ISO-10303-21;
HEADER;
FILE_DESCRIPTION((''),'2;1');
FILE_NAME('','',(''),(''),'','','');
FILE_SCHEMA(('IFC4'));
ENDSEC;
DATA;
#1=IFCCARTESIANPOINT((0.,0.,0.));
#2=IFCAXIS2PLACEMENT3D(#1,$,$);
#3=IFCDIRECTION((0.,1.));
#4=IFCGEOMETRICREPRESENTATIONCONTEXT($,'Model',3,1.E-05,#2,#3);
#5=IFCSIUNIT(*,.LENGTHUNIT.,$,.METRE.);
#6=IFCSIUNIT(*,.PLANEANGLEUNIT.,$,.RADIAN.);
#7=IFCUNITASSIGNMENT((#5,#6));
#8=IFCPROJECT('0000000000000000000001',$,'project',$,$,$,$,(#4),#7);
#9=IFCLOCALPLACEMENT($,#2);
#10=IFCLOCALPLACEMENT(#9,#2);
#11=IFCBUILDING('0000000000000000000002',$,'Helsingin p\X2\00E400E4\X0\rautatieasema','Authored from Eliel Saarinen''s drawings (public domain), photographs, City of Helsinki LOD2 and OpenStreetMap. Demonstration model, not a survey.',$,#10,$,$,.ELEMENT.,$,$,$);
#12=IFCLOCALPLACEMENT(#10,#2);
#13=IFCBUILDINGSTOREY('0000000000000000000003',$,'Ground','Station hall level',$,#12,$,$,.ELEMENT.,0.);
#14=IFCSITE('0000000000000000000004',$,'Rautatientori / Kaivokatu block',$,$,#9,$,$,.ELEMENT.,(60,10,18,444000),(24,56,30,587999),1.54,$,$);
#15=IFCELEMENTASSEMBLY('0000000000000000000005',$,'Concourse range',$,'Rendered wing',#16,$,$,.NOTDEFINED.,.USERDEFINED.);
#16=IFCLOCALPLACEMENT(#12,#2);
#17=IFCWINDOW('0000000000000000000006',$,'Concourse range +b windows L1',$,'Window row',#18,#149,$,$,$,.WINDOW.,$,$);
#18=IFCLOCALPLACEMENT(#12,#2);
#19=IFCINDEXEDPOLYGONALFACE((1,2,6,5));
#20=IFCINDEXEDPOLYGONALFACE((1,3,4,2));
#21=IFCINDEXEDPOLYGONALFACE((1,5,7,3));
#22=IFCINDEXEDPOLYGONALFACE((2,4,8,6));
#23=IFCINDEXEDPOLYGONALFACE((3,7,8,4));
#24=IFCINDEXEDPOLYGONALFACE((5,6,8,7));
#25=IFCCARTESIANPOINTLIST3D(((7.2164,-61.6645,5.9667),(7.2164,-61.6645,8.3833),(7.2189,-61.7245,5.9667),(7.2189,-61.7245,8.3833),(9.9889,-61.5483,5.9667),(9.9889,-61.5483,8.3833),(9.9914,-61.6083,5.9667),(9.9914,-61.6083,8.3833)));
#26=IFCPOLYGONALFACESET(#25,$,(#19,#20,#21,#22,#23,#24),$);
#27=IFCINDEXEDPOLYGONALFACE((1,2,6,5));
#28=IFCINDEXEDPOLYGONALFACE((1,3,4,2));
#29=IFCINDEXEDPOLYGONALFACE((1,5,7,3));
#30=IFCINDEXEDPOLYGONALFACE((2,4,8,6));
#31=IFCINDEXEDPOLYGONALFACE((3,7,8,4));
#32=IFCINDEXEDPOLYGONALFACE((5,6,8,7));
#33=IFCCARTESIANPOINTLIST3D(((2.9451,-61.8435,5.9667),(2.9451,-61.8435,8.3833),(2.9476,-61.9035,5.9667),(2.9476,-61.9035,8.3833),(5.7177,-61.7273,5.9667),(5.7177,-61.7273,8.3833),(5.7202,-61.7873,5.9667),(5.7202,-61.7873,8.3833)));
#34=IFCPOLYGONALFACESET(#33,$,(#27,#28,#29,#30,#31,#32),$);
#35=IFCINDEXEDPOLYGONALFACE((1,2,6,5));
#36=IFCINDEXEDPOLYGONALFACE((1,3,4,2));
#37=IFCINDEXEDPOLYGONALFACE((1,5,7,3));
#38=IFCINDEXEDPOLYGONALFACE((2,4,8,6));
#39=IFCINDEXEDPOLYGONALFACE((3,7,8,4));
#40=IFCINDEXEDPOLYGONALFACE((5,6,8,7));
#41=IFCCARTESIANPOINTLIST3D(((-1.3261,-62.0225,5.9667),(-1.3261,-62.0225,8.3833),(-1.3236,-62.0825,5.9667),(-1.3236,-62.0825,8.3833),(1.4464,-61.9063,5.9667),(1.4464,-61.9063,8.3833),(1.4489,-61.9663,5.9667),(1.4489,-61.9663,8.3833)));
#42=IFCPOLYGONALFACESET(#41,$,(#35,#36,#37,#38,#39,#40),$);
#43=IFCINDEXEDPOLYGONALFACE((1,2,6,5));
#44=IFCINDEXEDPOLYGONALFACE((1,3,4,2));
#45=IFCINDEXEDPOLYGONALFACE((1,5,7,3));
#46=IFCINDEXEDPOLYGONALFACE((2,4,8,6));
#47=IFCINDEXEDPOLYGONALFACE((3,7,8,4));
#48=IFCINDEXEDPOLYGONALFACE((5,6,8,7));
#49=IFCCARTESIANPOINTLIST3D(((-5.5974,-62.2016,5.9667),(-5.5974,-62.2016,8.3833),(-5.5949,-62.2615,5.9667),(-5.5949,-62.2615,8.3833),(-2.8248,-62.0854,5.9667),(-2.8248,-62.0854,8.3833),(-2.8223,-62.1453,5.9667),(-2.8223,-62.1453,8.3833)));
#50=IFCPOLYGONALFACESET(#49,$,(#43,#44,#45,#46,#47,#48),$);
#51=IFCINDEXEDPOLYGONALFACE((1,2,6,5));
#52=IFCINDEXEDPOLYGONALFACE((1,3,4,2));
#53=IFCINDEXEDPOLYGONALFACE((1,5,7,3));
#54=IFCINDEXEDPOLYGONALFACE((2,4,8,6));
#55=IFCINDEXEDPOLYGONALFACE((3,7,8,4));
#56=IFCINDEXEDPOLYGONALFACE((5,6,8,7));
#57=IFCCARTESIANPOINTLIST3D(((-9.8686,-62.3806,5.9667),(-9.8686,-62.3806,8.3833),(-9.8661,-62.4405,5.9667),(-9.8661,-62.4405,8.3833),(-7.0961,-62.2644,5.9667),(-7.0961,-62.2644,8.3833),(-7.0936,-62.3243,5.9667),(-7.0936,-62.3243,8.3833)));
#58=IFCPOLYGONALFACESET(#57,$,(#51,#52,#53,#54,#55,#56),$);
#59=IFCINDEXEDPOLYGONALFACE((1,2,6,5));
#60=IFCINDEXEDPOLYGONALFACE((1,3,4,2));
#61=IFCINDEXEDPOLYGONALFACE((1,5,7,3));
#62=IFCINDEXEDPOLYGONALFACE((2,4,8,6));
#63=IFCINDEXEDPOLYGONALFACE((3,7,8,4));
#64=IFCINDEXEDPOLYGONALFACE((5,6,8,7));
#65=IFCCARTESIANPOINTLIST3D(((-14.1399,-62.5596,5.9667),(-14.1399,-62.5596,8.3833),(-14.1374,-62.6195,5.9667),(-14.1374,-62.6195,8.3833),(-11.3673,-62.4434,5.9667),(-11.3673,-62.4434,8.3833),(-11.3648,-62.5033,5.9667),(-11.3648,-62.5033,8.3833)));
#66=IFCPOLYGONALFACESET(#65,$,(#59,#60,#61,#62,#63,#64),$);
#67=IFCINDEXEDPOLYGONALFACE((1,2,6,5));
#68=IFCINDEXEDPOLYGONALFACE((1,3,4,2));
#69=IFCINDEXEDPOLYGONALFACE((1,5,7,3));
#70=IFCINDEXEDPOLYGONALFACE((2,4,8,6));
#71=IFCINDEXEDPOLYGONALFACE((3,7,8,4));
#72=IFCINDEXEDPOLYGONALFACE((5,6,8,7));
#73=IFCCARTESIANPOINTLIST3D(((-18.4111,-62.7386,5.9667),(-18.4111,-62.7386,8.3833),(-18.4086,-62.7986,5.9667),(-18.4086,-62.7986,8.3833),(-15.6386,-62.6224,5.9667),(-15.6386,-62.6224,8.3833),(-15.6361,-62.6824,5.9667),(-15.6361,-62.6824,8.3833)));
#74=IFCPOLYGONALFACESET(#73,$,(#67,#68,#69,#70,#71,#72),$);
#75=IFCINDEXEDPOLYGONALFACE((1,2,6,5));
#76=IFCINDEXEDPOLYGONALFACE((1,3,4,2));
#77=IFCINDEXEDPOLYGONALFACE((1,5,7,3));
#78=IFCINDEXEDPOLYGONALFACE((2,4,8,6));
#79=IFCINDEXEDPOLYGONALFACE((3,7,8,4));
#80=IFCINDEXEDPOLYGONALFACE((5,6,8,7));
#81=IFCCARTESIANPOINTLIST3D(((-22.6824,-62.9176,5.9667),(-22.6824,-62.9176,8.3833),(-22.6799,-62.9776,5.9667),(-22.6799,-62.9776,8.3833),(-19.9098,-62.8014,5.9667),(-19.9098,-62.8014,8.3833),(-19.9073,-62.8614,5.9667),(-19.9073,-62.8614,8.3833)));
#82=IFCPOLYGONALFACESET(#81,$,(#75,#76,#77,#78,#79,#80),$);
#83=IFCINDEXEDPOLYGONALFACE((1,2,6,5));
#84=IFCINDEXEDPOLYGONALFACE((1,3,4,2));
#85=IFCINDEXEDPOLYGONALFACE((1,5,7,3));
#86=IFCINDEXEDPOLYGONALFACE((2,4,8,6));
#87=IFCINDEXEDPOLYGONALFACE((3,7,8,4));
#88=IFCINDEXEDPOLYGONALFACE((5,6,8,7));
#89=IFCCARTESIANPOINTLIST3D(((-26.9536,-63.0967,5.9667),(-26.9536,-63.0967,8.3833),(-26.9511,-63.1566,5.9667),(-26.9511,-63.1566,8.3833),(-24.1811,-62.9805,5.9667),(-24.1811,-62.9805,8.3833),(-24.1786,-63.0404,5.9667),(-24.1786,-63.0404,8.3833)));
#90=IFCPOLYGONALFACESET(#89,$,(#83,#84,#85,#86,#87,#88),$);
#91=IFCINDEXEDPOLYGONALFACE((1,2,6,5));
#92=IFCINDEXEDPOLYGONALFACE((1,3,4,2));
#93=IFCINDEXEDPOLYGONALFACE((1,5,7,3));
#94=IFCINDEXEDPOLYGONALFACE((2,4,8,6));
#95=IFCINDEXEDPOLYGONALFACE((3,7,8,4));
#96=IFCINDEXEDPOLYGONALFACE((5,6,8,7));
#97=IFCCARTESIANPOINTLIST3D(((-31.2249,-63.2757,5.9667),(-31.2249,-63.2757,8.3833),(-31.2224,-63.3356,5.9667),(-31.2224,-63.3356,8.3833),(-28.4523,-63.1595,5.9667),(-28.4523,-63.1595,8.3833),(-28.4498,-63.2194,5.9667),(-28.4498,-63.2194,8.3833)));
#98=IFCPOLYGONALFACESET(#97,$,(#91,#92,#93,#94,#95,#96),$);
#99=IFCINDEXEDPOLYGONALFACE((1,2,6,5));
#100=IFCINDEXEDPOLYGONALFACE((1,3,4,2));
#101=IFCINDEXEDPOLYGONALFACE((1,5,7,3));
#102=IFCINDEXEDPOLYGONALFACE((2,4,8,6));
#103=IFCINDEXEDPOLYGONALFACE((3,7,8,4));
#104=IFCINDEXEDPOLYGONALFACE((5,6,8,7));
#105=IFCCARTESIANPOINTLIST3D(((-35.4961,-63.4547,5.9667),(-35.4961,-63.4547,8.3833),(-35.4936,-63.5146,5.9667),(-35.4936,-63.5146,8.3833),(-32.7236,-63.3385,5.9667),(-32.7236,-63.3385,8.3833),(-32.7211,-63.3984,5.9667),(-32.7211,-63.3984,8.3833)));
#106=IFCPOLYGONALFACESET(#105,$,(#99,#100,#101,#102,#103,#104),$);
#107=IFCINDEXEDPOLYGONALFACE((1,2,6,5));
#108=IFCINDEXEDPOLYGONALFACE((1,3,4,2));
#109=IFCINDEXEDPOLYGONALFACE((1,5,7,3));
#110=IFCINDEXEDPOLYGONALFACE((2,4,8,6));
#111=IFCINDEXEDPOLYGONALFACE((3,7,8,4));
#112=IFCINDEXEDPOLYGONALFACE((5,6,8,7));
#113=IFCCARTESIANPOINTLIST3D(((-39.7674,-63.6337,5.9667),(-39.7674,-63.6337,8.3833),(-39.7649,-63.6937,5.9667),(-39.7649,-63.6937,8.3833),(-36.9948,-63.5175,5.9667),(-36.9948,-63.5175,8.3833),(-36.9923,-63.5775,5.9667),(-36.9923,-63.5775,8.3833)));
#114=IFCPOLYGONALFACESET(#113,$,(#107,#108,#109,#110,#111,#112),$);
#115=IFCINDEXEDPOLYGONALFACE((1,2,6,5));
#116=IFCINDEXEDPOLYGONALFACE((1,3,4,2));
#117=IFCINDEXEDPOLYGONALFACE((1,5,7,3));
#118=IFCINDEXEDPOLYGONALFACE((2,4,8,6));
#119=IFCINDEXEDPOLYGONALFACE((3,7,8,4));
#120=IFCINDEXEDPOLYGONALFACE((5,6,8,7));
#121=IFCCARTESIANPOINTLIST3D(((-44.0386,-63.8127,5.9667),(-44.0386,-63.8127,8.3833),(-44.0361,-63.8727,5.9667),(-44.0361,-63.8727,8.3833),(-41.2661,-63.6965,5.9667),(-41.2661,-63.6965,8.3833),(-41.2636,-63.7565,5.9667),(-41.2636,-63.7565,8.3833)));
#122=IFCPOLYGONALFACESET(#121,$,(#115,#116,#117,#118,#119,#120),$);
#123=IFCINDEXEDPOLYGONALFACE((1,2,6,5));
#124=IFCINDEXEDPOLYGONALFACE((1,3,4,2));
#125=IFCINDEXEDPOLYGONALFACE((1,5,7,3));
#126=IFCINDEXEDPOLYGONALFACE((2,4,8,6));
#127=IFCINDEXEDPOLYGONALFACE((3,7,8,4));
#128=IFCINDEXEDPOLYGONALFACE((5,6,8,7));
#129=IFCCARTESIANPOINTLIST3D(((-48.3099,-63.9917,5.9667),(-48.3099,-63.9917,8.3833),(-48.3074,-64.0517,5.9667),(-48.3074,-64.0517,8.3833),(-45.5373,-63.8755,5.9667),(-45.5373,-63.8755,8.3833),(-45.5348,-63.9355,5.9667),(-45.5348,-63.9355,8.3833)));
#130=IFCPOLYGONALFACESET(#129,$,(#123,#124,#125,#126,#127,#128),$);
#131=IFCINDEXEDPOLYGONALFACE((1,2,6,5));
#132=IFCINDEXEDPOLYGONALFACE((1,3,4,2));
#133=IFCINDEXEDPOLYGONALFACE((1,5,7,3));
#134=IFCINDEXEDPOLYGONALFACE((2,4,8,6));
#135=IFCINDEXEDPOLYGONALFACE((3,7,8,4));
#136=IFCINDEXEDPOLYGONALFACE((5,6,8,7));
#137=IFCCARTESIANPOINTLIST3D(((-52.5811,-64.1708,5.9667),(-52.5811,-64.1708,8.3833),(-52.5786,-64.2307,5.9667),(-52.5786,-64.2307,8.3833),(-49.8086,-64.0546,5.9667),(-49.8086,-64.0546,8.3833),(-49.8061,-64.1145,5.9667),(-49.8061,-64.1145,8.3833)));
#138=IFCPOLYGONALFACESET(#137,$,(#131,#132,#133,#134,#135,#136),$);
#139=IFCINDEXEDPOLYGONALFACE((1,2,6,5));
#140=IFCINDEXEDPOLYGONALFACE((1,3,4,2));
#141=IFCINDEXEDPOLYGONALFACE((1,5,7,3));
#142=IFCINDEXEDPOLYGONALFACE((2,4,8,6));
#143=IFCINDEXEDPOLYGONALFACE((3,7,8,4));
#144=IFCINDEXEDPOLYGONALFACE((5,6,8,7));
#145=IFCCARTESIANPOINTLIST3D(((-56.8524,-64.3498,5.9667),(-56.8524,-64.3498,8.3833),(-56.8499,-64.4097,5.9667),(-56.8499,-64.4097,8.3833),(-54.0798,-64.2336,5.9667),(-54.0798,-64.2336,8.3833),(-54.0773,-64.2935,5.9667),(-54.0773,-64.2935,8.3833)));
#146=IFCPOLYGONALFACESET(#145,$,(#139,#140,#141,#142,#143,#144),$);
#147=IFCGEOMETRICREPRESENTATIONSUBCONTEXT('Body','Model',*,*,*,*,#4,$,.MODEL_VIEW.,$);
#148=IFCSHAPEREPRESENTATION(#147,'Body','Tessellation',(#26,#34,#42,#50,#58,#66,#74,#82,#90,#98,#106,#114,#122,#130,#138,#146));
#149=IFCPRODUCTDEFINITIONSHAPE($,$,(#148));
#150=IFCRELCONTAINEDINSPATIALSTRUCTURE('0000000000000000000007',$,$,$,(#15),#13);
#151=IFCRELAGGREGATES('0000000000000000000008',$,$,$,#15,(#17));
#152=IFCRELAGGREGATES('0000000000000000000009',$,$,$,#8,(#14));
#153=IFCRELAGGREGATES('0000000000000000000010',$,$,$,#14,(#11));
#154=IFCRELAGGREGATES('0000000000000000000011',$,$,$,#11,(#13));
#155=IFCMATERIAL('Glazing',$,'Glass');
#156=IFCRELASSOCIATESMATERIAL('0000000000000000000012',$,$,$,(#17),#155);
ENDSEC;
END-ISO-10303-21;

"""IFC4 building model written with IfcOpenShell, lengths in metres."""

from ifc_helpers import new_model, si_unit, direction, frame, frame_2d, origin, place, context, subcontext, project, spatial, rectangle, extrude, material, element, aggregate, save


model = new_model("IFC4")

# Units and contexts
model_context = context("Model", 3, precision=1e-05, world=origin(), true_north=direction((0.0, 1.0)))
body_context = subcontext(model_context, "Body", "Model", "MODEL_VIEW")
ifc_project = project(units=[si_unit("LENGTHUNIT", "METRE"), si_unit("PLANEANGLEUNIT", "RADIAN")], contexts=[model_context])

# Site, building, storey
site_placement = place(None, origin())
site = spatial("IfcSite", under=ifc_project, at=site_placement, Name="Rautatientori / Kaivokatu block", CompositionType="ELEMENT", RefLatitude=(60, 10, 18, 444000), RefLongitude=(24, 56, 30, 587999), RefElevation=1.54)
building_placement = place(site_placement, origin())
building = spatial("IfcBuilding", under=site, at=building_placement, Name="Helsingin päärautatieasema", Description="Authored from Eliel Saarinen's drawings (public domain), photographs, City of Helsinki LOD2 and OpenStreetMap. Demonstration model, not a survey.", CompositionType="ELEMENT")
storey_placement = place(building_placement, origin())
storey = spatial("IfcBuildingStorey", under=building, at=storey_placement, Name="Ground", Description="Station hall level", CompositionType="ELEMENT", Elevation=0.0)

# Element assembly
assembly_1_placement = place(building_placement, origin())
assembly_1 = element("IfcElementAssembly", 1, at=assembly_1_placement, inside=storey, Name="Concourse range", ObjectType="Rendered wing", AssemblyPlace="NOTDEFINED", PredefinedType="USERDEFINED")

# Window
ifc_material_1 = material(Name="Glazing", Category="Glass")
window_1_placement = place(building_placement, origin())
window_1 = element("IfcWindow", 2, at=window_1_placement, material=ifc_material_1, Name="Concourse range +b windows L1", ObjectType="Window row", PredefinedType="WINDOW", context=body_context, shape_type="SweptSolid", body=[
    extrude(rectangle(XDim=2.775, YDim=0.06, at=frame_2d((0.0, 0.0), x_axis=(-0.999123, -0.041876))), frame((8.6039, -61.6364, 5.9667)), (0.0, 0.0, 1.0), 2.4167),
    extrude(rectangle(XDim=2.775, YDim=0.06, at=frame_2d((0.0, 0.0), x_axis=(-0.999123, -0.041876))), frame((4.3326, -61.8154, 5.9667)), (0.0, 0.0, 1.0), 2.4167),
    extrude(rectangle(XDim=2.775, YDim=0.06, at=frame_2d((0.0, 0.0), x_axis=(-0.999123, -0.041876))), frame((0.0614, -61.9944, 5.9667)), (0.0, 0.0, 1.0), 2.4167),
    extrude(rectangle(XDim=2.775, YDim=0.06, at=frame_2d((0.0, 0.0), x_axis=(-0.999123, -0.041876))), frame((-4.2099, -62.1734, 5.9667)), (0.0, 0.0, 1.0), 2.4167),
    extrude(rectangle(XDim=2.775, YDim=0.06, at=frame_2d((0.0, 0.0), x_axis=(-0.999123, -0.041876))), frame((-8.4811, -62.3525, 5.9667)), (0.0, 0.0, 1.0), 2.4167),
    extrude(rectangle(XDim=2.775, YDim=0.06, at=frame_2d((0.0, 0.0), x_axis=(-0.999123, -0.041876))), frame((-12.7524, -62.5315, 5.9667)), (0.0, 0.0, 1.0), 2.4167),
    extrude(rectangle(XDim=2.775, YDim=0.06, at=frame_2d((0.0, 0.0), x_axis=(-0.999123, -0.041876))), frame((-17.0236, -62.7105, 5.9667)), (0.0, 0.0, 1.0), 2.4167),
    extrude(rectangle(XDim=2.775, YDim=0.06, at=frame_2d((0.0, 0.0), x_axis=(-0.999123, -0.041876))), frame((-21.2949, -62.8895, 5.9667)), (0.0, 0.0, 1.0), 2.4167),
    extrude(rectangle(XDim=2.775, YDim=0.06, at=frame_2d((0.0, 0.0), x_axis=(-0.999123, -0.041876))), frame((-25.5661, -63.0685, 5.9667)), (0.0, 0.0, 1.0), 2.4167),
    extrude(rectangle(XDim=2.775, YDim=0.06, at=frame_2d((0.0, 0.0), x_axis=(-0.999123, -0.041876))), frame((-29.8374, -63.2475, 5.9667)), (0.0, 0.0, 1.0), 2.4167),
    extrude(rectangle(XDim=2.775, YDim=0.06, at=frame_2d((0.0, 0.0), x_axis=(-0.999123, -0.041876))), frame((-34.1086, -63.4266, 5.9667)), (0.0, 0.0, 1.0), 2.4167),
    extrude(rectangle(XDim=2.775, YDim=0.06, at=frame_2d((0.0, 0.0), x_axis=(-0.999123, -0.041876))), frame((-38.3799, -63.6056, 5.9667)), (0.0, 0.0, 1.0), 2.4167),
    extrude(rectangle(XDim=2.775, YDim=0.06, at=frame_2d((0.0, 0.0), x_axis=(-0.999123, -0.041876))), frame((-42.6511, -63.7846, 5.9667)), (0.0, 0.0, 1.0), 2.4167),
    extrude(rectangle(XDim=2.775, YDim=0.06, at=frame_2d((0.0, 0.0), x_axis=(-0.999123, -0.041876))), frame((-46.9224, -63.9636, 5.9667)), (0.0, 0.0, 1.0), 2.4167),
    extrude(rectangle(XDim=2.775, YDim=0.06, at=frame_2d((0.0, 0.0), x_axis=(-0.999123, -0.041876))), frame((-51.1936, -64.1426, 5.9667)), (0.0, 0.0, 1.0), 2.4167),
    extrude(rectangle(XDim=2.775, YDim=0.06, at=frame_2d((0.0, 0.0), x_axis=(-0.999123, -0.041876))), frame((-55.4649, -64.3217, 5.9667)), (0.0, 0.0, 1.0), 2.4167),
])

aggregate(assembly_1, [window_1])

save(model, "model.ifc")
